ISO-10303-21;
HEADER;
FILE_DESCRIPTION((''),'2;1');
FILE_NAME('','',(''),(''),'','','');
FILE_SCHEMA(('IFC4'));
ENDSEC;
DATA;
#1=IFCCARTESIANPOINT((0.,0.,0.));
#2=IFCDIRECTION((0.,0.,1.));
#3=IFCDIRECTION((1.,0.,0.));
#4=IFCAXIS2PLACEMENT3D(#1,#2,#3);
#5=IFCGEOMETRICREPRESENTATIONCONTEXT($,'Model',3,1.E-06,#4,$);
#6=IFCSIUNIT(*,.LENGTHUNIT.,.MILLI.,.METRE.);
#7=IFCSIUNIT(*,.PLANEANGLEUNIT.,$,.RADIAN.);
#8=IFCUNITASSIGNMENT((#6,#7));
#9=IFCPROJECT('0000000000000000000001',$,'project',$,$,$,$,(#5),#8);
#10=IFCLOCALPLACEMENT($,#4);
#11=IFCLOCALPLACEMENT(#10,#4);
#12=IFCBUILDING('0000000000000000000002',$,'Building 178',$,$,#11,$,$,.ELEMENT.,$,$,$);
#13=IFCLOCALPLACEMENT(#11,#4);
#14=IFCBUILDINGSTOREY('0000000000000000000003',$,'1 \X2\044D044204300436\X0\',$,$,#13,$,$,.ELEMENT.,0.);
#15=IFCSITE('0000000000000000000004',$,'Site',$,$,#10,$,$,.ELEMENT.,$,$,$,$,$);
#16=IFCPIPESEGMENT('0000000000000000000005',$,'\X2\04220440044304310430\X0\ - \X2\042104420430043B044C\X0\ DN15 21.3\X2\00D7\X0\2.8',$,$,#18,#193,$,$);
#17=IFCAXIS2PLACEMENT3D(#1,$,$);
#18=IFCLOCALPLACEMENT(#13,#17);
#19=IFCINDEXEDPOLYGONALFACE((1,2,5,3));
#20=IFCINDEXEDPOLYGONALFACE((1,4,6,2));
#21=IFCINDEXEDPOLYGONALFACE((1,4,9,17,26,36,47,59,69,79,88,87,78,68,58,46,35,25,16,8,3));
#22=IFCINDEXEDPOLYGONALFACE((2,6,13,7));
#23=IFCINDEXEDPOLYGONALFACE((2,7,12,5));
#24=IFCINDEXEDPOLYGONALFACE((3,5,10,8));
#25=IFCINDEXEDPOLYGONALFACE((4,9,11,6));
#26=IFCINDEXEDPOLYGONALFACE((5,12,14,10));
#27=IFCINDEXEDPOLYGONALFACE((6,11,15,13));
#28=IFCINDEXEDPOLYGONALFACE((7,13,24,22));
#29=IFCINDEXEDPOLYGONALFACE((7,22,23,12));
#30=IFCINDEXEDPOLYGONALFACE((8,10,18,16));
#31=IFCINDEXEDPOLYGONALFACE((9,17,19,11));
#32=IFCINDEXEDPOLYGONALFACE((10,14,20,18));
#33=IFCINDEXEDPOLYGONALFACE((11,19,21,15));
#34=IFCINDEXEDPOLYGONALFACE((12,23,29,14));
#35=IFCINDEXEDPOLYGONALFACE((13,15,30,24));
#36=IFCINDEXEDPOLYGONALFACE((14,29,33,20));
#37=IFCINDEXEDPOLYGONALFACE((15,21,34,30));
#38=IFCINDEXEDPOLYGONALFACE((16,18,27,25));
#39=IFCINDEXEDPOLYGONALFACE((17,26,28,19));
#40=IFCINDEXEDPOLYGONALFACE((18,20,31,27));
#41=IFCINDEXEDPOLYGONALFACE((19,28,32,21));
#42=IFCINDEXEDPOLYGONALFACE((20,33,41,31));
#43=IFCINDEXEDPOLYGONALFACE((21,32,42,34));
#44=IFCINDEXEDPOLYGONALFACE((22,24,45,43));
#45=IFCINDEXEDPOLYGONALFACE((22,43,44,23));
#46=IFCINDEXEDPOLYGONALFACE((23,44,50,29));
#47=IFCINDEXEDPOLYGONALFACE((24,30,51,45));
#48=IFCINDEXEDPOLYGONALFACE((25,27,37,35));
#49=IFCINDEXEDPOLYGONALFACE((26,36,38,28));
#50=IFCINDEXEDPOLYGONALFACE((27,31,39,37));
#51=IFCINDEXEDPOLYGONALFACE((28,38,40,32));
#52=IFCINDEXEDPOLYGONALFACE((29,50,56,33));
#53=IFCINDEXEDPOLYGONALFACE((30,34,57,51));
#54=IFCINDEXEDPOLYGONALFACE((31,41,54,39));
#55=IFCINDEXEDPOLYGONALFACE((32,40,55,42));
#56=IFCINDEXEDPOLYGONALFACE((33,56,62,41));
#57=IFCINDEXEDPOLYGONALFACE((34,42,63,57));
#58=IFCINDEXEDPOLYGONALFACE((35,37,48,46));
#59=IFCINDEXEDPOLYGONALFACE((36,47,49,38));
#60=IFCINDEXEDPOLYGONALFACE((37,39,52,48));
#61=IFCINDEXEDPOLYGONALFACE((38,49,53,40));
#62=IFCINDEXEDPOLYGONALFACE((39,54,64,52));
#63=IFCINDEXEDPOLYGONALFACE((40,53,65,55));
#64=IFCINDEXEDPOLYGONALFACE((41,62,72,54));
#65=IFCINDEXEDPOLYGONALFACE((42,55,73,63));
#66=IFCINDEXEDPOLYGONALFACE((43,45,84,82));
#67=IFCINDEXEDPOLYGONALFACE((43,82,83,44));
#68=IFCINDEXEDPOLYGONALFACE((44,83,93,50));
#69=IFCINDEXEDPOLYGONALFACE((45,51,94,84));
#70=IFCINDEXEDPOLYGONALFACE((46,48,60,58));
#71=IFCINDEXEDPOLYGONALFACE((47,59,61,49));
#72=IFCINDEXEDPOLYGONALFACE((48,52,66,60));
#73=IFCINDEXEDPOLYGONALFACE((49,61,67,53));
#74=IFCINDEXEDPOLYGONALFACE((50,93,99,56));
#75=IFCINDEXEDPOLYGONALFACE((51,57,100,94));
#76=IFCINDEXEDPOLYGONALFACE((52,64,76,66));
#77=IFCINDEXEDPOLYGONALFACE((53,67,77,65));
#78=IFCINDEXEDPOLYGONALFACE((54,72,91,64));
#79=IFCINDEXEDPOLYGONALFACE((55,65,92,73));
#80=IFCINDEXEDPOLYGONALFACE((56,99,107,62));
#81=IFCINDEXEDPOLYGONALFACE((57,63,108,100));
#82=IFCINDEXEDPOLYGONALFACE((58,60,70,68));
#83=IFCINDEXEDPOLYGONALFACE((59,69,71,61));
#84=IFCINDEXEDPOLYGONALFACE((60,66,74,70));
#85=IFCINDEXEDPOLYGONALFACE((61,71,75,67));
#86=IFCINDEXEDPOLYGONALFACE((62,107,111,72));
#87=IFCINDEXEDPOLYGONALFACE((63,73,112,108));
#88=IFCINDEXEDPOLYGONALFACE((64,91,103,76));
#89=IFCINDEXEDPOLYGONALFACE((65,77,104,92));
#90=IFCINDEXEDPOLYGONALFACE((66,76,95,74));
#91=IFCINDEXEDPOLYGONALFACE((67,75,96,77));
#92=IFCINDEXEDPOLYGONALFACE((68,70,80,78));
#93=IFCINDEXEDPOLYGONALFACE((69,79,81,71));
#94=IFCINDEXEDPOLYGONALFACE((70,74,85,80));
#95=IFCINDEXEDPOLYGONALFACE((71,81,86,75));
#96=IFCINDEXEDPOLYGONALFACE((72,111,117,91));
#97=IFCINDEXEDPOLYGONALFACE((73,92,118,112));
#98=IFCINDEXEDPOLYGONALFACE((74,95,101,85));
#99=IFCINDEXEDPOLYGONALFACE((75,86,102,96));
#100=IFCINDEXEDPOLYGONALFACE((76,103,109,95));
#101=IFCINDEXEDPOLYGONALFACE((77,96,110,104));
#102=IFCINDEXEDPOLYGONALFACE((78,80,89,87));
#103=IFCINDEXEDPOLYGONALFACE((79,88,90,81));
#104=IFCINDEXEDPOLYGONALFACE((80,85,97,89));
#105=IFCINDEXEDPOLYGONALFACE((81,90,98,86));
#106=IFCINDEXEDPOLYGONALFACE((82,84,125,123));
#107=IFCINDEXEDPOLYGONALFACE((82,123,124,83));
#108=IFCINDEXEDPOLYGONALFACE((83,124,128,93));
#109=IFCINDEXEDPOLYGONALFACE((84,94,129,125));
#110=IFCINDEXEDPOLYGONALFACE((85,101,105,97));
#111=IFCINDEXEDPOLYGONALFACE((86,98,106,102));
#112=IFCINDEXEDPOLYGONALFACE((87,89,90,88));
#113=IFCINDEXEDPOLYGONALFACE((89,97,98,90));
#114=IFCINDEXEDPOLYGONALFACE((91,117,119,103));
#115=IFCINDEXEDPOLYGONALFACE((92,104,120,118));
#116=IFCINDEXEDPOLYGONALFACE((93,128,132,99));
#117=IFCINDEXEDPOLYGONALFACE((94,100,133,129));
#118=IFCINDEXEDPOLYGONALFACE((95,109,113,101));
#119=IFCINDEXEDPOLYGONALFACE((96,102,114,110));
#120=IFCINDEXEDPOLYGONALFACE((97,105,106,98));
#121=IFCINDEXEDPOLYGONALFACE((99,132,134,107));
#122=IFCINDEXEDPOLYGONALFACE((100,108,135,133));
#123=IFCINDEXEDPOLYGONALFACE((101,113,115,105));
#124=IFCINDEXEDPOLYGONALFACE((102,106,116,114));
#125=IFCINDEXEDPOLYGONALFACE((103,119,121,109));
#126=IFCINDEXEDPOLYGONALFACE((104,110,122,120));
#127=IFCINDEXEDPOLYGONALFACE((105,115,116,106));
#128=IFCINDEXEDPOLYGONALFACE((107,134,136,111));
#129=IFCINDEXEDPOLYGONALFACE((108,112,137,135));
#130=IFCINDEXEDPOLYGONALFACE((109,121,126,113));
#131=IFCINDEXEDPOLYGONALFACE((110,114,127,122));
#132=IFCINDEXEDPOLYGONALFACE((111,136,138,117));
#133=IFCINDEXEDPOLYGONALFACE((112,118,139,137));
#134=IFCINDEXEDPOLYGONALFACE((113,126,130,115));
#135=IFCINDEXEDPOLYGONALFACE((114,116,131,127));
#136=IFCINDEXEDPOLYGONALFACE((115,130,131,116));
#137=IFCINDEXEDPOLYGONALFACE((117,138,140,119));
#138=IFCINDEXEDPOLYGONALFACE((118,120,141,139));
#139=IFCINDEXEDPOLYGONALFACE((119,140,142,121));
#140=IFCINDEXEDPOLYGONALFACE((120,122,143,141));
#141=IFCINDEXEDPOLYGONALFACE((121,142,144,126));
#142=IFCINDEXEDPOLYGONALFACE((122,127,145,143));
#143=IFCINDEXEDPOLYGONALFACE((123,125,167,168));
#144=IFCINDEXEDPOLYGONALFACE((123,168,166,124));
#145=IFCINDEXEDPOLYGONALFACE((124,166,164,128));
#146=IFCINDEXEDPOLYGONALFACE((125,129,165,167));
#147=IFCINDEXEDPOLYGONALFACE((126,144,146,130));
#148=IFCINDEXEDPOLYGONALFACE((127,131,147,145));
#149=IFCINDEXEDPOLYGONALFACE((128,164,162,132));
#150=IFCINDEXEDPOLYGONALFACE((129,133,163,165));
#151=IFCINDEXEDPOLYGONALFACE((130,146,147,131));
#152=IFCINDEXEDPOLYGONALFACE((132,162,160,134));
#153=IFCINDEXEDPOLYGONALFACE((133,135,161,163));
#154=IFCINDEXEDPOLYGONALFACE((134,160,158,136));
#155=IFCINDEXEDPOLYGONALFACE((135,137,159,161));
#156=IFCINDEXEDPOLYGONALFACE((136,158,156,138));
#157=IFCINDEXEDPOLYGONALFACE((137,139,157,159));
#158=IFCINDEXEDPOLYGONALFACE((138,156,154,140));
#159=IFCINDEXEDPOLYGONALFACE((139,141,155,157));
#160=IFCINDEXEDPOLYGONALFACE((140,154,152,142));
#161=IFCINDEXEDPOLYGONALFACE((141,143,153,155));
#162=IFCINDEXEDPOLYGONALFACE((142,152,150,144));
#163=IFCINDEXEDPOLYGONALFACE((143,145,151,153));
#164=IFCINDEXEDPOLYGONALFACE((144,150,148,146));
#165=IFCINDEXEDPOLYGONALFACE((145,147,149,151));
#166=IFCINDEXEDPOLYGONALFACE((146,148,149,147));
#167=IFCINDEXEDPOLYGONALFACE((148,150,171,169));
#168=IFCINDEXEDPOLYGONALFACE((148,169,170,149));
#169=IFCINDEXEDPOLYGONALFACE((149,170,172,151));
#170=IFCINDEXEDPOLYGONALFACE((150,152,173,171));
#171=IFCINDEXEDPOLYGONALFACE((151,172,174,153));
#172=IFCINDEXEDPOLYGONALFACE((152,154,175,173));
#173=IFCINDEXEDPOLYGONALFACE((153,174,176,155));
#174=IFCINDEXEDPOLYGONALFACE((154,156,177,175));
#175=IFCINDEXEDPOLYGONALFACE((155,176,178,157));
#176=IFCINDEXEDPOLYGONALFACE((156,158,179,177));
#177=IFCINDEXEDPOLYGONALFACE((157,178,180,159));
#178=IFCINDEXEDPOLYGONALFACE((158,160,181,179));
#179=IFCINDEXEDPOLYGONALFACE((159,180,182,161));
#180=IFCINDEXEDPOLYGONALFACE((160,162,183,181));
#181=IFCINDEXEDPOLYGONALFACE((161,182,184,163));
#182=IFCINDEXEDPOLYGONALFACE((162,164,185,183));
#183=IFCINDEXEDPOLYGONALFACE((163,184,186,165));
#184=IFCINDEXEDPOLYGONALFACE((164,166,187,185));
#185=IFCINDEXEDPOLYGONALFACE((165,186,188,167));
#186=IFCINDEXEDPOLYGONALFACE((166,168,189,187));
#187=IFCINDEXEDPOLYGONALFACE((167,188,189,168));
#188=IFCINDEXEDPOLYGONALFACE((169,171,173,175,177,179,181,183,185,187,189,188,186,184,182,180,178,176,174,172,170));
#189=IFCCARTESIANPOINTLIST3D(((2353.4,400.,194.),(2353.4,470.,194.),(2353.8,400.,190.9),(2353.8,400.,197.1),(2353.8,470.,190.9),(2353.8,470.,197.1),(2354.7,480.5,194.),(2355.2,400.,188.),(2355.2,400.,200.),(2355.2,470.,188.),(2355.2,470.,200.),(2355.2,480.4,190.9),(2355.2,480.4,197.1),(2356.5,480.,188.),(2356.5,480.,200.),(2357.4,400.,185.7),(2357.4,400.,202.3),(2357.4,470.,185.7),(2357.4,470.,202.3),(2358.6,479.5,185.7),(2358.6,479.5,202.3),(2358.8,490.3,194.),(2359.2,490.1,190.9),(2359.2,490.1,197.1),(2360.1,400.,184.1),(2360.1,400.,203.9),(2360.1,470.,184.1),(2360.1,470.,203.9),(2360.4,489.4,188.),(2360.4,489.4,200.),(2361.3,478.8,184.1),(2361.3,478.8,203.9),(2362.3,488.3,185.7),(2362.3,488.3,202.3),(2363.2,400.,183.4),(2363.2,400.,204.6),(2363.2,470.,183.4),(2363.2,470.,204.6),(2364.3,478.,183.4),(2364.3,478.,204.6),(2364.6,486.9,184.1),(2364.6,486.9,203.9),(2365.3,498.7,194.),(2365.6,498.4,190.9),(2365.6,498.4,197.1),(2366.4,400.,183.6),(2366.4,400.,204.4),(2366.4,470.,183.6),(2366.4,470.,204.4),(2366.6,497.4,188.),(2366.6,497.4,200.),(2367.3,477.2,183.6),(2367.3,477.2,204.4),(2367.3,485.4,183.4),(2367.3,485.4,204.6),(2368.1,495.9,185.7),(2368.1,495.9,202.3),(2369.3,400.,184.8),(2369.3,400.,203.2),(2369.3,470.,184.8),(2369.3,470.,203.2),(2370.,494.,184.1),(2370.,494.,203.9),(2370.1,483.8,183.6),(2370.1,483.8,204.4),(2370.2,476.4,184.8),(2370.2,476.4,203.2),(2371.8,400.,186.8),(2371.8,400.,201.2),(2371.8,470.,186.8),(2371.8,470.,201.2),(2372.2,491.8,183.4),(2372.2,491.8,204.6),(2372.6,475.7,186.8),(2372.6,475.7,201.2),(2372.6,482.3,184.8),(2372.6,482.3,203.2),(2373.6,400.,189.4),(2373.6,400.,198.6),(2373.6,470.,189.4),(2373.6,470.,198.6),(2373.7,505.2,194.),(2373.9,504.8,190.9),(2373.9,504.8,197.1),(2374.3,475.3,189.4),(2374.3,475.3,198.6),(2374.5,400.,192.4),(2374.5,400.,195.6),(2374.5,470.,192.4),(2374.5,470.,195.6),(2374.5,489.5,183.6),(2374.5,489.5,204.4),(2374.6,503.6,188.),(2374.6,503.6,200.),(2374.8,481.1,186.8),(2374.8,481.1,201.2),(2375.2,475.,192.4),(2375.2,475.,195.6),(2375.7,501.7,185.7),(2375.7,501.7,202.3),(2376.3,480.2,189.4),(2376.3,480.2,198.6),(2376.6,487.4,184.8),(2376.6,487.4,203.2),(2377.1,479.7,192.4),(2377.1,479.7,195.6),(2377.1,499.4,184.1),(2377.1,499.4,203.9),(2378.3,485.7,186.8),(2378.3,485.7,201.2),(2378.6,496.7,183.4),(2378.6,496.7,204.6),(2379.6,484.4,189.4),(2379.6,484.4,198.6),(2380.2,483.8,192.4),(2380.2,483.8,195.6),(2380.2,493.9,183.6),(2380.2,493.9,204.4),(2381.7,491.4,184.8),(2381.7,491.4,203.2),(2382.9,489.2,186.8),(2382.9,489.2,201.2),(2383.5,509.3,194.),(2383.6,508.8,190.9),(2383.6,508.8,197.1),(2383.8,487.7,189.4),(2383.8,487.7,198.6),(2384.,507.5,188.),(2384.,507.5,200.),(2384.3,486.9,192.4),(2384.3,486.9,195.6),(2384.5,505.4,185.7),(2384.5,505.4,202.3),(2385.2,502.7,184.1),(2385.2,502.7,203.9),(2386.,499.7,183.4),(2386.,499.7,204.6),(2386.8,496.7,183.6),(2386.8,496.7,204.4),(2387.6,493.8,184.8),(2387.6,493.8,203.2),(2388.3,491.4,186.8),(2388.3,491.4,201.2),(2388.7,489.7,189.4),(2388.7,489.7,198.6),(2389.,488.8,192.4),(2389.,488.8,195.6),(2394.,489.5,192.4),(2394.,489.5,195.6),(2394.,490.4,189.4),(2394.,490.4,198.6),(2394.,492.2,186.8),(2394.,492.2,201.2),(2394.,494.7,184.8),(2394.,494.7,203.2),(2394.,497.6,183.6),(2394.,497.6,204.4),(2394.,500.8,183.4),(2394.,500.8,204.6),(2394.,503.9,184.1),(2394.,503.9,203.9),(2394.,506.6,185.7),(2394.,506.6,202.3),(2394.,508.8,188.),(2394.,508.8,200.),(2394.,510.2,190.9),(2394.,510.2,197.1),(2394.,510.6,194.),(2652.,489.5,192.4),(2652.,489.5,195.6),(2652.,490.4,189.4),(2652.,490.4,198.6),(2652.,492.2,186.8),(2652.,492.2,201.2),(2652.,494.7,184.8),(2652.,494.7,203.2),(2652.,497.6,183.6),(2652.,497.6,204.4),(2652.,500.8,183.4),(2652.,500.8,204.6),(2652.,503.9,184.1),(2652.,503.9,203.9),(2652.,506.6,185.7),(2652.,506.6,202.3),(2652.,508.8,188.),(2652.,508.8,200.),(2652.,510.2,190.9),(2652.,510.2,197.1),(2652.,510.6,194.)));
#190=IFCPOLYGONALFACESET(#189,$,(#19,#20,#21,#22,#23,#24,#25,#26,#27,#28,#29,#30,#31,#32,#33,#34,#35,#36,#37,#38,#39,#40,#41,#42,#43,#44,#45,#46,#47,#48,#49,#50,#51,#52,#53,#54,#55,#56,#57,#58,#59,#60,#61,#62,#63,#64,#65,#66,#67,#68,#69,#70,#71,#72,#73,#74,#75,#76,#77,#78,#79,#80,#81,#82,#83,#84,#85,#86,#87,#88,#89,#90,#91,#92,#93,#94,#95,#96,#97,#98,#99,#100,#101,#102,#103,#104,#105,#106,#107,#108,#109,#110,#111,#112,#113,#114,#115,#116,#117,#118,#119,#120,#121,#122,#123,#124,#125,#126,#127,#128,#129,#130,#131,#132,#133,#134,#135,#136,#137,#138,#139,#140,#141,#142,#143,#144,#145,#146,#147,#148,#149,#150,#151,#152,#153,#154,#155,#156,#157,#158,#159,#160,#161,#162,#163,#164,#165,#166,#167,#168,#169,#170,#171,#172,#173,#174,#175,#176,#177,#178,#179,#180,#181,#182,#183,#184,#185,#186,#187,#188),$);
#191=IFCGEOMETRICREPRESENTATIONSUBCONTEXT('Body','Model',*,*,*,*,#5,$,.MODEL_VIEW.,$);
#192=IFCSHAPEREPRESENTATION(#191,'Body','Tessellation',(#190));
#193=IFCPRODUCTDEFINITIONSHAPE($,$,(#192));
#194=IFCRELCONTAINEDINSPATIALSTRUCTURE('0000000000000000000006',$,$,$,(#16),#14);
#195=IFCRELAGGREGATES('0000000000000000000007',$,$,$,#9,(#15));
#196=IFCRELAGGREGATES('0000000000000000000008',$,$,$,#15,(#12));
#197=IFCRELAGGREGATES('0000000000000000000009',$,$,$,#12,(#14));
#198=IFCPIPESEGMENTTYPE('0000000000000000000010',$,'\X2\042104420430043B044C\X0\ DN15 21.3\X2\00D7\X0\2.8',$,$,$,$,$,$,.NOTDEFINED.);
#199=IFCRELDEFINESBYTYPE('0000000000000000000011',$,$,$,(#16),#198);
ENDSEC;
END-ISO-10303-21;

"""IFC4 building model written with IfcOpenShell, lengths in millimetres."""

from ifc_helpers import new_model, entity, si_unit, frame, origin_with_axes, place, context, subcontext, project, spatial, source, transform, mapped, type_object, element, save


model = new_model("IFC4")

# Units and contexts
model_context = context("Model", 3, precision=1e-06, world=origin_with_axes())
body_context = subcontext(model_context, "Body", "Model", "MODEL_VIEW")
ifc_project = project(units=[si_unit("LENGTHUNIT", "METRE", prefix="MILLI"), si_unit("PLANEANGLEUNIT", "RADIAN")], contexts=[model_context])

# Site, building, storey
site_placement = place(None, origin_with_axes())
site = spatial("IfcSite", under=ifc_project, at=site_placement, Name="Site", CompositionType="ELEMENT")
building_placement = place(site_placement, origin_with_axes())
building = spatial("IfcBuilding", under=site, at=building_placement, Name="Building 178", CompositionType="ELEMENT")
storey_placement = place(building_placement, origin_with_axes())
storey = spatial("IfcBuildingStorey", under=building, at=storey_placement, Name="1 этаж", CompositionType="ELEMENT", Elevation=0.0)

# Pipe segment
pipe_segment_type = type_object("IfcPipeSegmentType", Name="Сталь DN15 21.3×2.8", PredefinedType="NOTDEFINED")
shared_shape_1 = source(origin_with_axes(), body_context, "Body", "AdvancedSweptSolid", [
    entity("IfcSweptDiskSolid", entity("IfcIndexedPolyCurve", entity("IfcCartesianPointList3D", [[0.0, 0.0, 0.0], [0.0, 0.0, -70.0], [8.8, 0.0, -91.2], [30.0, 0.0, -100.0], [288.0, 0.0, -100.0]]), [entity("IfcLineIndex", [1, 2]), entity("IfcArcIndex", [2, 3, 4]), entity("IfcLineIndex", [4, 5])]), 10.7),
])
for number, where, z_axis, x_axis, name in (
    (1, (2364.0, 400.0, 194.0), (0.0, -1.0, 0.0), (1.0, 0.0, 0.0), "Труба - Сталь DN15 21.3×2.8"),
):
    element("IfcPipeSegment", number, at=place(storey_placement, frame(where, z_axis=z_axis, x_axis=x_axis)), inside=storey, type_object=pipe_segment_type, Name=name, context=body_context, shape_type="MappedRepresentation", body=[
        mapped(shared_shape_1, transform((0.0, 0.0, 0.0), x_axis=(1.0, 0.0, 0.0), y_axis=(0.0, 1.0, 0.0), z_axis=(0.0, 0.0, 1.0), scale=1.0)),
    ])

save(model, "model.ifc")
